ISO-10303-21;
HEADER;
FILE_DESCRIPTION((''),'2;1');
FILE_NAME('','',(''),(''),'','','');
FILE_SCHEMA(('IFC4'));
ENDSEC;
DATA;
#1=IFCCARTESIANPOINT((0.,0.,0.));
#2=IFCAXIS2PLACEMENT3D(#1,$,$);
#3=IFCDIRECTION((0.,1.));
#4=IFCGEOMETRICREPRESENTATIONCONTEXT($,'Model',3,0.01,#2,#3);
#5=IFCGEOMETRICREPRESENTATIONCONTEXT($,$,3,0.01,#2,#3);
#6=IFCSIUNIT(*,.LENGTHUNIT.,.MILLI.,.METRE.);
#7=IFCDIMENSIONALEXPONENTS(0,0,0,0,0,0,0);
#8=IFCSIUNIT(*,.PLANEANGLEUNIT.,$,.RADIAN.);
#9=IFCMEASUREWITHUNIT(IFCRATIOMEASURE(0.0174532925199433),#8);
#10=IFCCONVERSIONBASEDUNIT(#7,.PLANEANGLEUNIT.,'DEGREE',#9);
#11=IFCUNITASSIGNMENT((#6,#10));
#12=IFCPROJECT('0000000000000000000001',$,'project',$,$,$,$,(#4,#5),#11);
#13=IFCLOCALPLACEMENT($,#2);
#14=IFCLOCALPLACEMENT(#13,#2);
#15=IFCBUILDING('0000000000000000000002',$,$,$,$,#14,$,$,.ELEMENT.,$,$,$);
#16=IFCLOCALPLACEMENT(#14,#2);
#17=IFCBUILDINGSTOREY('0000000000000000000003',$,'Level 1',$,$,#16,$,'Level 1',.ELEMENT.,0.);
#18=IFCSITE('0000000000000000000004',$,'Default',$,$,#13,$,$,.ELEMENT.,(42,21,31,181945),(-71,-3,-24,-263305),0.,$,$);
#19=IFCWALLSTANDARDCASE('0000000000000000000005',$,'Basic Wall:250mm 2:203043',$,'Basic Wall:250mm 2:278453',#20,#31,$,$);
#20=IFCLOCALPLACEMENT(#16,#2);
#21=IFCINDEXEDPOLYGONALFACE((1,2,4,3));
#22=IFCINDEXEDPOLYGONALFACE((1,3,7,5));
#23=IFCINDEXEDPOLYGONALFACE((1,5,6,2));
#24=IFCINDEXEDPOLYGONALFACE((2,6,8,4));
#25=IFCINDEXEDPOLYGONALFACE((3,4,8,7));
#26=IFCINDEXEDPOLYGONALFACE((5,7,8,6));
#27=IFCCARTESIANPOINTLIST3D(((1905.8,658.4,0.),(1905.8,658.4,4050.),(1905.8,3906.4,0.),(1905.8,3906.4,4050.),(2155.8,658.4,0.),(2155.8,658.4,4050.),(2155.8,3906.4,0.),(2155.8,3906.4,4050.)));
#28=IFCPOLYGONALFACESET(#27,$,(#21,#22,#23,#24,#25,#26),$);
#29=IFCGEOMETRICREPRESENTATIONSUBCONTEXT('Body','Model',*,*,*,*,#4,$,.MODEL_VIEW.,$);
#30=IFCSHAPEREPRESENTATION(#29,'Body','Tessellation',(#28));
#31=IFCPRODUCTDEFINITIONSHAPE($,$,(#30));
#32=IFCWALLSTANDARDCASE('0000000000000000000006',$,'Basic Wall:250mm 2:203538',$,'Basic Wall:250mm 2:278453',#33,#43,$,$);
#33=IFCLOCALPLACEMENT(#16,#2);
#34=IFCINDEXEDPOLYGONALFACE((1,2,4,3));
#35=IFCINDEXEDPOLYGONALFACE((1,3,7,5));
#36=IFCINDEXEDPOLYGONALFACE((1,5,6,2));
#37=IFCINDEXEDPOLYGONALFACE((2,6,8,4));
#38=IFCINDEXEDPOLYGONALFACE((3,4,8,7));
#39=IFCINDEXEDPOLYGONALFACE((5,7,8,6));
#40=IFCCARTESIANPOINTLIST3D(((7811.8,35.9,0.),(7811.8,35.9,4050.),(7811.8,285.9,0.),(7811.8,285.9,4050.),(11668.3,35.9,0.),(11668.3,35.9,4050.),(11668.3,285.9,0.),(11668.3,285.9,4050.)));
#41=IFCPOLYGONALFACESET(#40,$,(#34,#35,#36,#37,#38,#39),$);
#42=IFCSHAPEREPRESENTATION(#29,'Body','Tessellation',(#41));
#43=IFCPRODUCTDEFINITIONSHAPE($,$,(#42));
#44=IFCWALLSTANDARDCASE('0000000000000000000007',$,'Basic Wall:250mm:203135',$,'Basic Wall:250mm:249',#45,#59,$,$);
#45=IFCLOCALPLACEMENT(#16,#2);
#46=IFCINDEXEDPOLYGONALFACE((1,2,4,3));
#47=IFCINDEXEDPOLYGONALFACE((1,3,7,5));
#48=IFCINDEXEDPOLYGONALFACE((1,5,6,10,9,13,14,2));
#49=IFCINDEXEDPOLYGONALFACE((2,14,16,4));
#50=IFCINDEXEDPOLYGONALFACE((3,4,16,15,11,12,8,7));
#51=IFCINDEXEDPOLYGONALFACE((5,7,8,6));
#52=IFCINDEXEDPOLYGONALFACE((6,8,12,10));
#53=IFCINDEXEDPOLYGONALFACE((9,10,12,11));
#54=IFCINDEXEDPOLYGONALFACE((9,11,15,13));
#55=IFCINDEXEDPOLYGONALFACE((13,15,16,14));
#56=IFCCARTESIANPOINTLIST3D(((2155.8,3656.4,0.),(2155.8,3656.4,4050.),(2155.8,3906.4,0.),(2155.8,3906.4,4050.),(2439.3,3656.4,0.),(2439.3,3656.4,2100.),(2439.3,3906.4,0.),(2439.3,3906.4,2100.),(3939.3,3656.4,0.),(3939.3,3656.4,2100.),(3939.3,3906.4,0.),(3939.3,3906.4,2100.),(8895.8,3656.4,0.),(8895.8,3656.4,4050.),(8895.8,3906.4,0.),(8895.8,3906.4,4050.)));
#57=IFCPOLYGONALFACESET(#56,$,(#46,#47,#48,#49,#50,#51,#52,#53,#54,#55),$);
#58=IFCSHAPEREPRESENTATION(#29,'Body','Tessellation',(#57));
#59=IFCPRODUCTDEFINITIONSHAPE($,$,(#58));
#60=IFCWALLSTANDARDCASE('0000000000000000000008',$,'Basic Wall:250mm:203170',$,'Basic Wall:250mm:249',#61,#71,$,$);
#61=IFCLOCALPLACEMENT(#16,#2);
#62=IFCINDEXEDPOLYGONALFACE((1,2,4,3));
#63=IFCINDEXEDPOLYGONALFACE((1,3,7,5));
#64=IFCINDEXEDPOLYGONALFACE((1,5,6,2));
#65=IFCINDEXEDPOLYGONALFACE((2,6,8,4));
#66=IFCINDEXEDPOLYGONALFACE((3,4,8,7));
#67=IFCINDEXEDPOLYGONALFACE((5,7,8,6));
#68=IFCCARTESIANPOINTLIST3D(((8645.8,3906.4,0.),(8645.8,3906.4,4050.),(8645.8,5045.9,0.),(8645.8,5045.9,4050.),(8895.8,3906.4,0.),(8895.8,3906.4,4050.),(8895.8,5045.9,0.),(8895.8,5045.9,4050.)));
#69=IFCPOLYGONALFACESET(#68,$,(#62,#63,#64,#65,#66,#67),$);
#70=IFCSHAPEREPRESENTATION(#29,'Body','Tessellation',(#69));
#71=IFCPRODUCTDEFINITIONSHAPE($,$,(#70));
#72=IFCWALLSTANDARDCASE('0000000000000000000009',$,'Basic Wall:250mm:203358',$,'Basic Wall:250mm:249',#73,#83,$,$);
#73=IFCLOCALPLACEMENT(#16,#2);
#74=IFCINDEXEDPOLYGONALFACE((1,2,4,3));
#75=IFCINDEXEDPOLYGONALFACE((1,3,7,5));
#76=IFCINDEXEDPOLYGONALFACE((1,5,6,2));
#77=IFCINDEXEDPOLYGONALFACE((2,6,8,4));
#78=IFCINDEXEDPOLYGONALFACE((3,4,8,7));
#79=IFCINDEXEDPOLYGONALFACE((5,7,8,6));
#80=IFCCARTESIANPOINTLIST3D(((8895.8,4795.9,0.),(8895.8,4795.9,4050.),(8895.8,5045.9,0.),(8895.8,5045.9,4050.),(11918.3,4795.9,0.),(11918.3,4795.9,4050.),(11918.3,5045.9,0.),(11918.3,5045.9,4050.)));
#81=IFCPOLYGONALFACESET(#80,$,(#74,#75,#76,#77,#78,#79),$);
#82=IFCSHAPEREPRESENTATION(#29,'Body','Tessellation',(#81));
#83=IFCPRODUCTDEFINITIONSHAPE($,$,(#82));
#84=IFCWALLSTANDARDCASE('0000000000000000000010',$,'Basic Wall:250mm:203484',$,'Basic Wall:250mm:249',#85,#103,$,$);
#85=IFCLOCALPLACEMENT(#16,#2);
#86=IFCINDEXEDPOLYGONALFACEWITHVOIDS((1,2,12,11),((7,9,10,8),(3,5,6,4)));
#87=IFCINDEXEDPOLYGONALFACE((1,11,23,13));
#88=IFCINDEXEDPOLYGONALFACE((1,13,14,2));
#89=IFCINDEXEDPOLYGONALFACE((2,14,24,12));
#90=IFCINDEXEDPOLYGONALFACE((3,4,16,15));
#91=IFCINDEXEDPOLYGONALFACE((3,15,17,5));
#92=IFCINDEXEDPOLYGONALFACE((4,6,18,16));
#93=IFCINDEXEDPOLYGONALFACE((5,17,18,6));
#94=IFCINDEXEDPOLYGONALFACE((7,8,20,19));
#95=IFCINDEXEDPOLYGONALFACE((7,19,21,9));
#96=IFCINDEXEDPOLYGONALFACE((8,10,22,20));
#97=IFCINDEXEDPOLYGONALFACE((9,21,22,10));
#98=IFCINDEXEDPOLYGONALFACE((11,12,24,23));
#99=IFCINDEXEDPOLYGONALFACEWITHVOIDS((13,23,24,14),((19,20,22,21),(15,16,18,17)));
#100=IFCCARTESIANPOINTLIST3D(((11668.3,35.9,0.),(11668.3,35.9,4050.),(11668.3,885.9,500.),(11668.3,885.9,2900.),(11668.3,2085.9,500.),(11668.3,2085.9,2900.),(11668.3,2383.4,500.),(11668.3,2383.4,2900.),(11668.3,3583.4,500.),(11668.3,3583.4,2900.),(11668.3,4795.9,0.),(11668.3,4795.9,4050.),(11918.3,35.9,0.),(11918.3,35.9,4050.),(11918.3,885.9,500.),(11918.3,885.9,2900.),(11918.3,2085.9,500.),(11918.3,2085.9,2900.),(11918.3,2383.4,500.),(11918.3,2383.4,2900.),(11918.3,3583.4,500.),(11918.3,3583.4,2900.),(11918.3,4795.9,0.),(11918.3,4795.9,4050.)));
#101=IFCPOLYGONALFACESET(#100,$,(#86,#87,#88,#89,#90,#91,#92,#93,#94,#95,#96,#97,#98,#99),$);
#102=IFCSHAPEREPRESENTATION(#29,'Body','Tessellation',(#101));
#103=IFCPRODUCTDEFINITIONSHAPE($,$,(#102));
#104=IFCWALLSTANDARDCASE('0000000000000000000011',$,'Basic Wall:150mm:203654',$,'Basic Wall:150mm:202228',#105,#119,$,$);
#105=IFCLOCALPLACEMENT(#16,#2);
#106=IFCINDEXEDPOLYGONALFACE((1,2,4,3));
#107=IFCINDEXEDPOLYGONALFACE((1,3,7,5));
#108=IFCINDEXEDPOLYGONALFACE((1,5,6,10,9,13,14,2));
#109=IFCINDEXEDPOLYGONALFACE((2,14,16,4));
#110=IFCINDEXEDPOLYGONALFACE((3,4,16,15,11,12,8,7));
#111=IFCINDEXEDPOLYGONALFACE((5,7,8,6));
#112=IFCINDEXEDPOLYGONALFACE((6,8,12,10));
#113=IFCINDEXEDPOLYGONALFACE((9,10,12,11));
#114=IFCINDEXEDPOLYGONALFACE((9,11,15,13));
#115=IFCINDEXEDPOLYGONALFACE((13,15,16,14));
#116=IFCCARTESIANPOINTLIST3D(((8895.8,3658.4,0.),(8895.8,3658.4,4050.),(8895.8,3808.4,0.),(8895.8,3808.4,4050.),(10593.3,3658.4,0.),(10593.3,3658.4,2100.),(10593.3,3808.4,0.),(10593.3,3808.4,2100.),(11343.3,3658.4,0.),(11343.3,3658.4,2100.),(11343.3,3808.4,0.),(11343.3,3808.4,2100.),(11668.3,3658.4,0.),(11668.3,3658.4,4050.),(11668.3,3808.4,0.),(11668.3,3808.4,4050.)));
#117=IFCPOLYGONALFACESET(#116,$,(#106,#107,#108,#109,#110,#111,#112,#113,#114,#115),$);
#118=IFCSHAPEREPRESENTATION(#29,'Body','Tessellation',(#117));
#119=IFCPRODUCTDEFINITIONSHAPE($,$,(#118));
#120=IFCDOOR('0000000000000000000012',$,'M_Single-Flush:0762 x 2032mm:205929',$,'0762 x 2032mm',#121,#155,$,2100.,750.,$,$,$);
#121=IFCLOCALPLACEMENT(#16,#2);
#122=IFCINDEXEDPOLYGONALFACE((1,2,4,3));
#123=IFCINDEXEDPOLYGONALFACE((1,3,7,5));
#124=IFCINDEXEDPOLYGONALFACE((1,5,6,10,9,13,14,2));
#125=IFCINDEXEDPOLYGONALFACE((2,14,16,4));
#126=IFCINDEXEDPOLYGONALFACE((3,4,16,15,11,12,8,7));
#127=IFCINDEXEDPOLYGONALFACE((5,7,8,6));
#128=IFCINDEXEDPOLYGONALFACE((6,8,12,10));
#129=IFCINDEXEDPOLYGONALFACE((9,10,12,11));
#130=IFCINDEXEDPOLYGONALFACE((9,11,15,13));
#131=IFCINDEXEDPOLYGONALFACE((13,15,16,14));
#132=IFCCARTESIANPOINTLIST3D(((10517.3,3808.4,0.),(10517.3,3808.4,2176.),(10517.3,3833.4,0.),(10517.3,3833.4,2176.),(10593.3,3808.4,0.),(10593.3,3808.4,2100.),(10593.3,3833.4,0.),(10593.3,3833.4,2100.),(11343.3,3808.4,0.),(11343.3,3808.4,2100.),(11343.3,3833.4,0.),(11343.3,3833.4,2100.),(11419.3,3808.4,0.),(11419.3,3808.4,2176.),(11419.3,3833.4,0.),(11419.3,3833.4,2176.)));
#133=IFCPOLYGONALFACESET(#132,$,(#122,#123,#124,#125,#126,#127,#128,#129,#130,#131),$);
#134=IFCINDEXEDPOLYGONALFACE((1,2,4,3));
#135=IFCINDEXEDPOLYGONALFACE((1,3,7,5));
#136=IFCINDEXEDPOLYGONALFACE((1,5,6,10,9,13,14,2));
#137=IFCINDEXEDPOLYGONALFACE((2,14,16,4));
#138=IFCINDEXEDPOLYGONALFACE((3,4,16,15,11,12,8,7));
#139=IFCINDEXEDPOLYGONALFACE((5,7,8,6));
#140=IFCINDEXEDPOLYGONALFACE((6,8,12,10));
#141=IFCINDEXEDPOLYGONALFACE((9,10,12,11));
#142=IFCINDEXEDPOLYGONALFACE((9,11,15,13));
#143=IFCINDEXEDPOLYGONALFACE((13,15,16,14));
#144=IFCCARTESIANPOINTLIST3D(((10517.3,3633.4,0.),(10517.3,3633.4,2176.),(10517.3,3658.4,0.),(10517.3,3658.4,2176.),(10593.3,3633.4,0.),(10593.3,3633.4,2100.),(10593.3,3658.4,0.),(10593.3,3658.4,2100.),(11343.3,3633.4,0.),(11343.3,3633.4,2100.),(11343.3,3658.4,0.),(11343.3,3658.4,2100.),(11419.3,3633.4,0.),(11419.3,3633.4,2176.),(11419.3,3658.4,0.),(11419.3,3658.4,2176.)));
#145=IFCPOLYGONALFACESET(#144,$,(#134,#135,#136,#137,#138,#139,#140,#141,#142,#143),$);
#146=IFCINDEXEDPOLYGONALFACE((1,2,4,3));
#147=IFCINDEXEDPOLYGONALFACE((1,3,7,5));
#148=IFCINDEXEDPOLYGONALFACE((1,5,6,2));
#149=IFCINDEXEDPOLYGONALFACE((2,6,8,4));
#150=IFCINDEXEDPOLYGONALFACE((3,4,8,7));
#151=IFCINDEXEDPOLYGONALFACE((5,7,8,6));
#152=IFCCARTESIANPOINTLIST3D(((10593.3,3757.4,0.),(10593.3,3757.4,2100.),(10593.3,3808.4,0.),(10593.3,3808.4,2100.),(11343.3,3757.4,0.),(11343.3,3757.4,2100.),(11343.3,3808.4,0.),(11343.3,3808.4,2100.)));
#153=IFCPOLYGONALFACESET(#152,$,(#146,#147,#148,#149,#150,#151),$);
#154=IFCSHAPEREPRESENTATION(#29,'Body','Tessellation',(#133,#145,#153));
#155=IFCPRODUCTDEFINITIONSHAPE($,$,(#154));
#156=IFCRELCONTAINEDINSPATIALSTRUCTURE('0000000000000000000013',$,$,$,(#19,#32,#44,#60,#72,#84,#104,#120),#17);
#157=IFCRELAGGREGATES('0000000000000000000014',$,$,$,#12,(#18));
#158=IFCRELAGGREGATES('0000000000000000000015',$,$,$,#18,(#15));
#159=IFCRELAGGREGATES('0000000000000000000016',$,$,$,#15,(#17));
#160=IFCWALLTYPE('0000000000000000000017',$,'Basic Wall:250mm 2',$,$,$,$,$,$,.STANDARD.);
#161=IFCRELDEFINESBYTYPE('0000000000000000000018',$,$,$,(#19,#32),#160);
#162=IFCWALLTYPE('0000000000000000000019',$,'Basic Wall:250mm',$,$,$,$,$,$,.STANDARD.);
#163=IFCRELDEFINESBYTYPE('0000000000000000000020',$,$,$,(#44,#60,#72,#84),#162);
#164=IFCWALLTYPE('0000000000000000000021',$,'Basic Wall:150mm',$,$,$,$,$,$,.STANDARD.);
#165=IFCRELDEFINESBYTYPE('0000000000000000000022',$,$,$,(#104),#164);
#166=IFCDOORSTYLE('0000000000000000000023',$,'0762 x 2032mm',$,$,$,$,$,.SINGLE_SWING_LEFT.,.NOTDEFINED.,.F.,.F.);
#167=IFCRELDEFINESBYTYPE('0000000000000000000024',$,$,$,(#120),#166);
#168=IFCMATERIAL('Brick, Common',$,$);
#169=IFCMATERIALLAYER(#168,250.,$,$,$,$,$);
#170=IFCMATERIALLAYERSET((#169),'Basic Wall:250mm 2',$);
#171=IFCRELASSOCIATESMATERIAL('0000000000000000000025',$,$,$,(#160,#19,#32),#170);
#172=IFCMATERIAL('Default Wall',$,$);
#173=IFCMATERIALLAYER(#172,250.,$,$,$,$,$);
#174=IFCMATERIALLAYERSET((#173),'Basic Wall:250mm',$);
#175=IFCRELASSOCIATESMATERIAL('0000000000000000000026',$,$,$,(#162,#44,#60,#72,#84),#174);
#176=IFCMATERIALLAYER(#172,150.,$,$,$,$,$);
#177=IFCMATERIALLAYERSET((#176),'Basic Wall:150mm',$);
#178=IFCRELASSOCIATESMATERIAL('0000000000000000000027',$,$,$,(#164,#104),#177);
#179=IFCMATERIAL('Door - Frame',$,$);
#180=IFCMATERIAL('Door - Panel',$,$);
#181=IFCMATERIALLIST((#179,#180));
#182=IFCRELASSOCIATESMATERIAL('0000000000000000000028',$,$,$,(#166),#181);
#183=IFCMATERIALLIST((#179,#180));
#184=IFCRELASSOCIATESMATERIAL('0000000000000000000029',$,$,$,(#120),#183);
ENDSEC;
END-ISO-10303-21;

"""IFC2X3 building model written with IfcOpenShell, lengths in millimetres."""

from ifc_helpers import new_model, entity, si_unit, converted_unit, direction, frame, frame_2d, origin, place, context, subcontext, project, spatial, polyline, rectangle, outline, extrude, source, transform, mapped, material, material_list, layer, layer_set, layer_usage, type_object, type_shapes, element, fill, save


model = new_model("IFC2X3")

# Units and contexts
model_context = context("Model", 3, precision=0.01, world=origin(), true_north=direction((0.0, 1.0)))
context_of_model = context(None, 3, precision=0.01, world=origin(), true_north=direction((0.0, 1.0)))
body_context = subcontext(model_context, "Body", "Model", "MODEL_VIEW")
ifc_project = project(units=[si_unit("LENGTHUNIT", "METRE", prefix="MILLI"), converted_unit("PLANEANGLEUNIT", "DEGREE", entity("IfcRatioMeasure", 0.0174532925199433), si_unit("PLANEANGLEUNIT", "RADIAN"), dimensions=[0, 0, 0, 0, 0, 0, 0])], contexts=[model_context, context_of_model])

# Site, building, storey
site_placement = place(None, origin())
site = spatial("IfcSite", under=ifc_project, at=site_placement, Name="Default", CompositionType="ELEMENT", RefLatitude=(42, 21, 31, 181945), RefLongitude=(-71, -3, -24, -263305), RefElevation=0.0)
building_placement = place(site_placement, origin())
building = spatial("IfcBuilding", under=site, at=building_placement, CompositionType="ELEMENT")
storey_placement = place(building_placement, origin())
storey = spatial("IfcBuildingStorey", under=building, at=storey_placement, Name="Level 1", LongName="Level 1", CompositionType="ELEMENT", Elevation=0.0)

# Shared definitions
ifc_material_1 = material(Name="Default Wall")

# Walls
ifc_material_2 = material(Name="Brick, Common")
ifc_layer_1 = layer(ifc_material_2, 250.0)
ifc_layer_set_1 = layer_set([ifc_layer_1], Name="Basic Wall:250mm 2")
ifc_layer_usage_1 = layer_usage(ifc_layer_set_1, "AXIS2", "NEGATIVE", 125.0)
wall_type_1 = type_object("IfcWallType", Name="Basic Wall:250mm 2", PredefinedType="STANDARD", material=ifc_layer_set_1)
wall_1_placement = place(storey_placement, frame((2030.8, 3906.4, 0.0), z_axis=(0.0, 0.0, 1.0), x_axis=(0.0, -1.0, 0.0)))
element("IfcWallStandardCase", 1, at=wall_1_placement, inside=storey, type_object=wall_type_1, material=ifc_layer_usage_1, Name="Basic Wall:250mm 2:203043", ObjectType="Basic Wall:250mm 2:278453", context=body_context, shape_type="SweptSolid", body=[
    extrude(rectangle(XDim=3248.1, YDim=250.0, at=frame_2d((1624.0, 0.0), x_axis=(-1.0, 0.0))), origin(), (0.0, 0.0, 1.0), 4050.0),
])
ifc_layer_usage_2 = layer_usage(ifc_layer_set_1, "AXIS2", "NEGATIVE", 125.0)
wall_2_placement = place(storey_placement, frame((11668.3, 160.9, 0.0), z_axis=(0.0, 0.0, 1.0), x_axis=(-1.0, 0.0, 0.0)))
element("IfcWallStandardCase", 2, at=wall_2_placement, inside=storey, type_object=wall_type_1, material=ifc_layer_usage_2, Name="Basic Wall:250mm 2:203538", ObjectType="Basic Wall:250mm 2:278453", context=body_context, shape_type="SweptSolid", body=[
    extrude(rectangle(XDim=3856.5, YDim=250.0, at=frame_2d((1928.2, 0.0), x_axis=(-1.0, 0.0))), origin(), (0.0, 0.0, 1.0), 4050.0),
])

# Wall, opening
ifc_layer_2 = layer(ifc_material_1, 250.0)
ifc_layer_set_2 = layer_set([ifc_layer_2], Name="Basic Wall:250mm")
ifc_layer_usage_3 = layer_usage(ifc_layer_set_2, "AXIS2", "NEGATIVE", 125.0)
wall_type_2 = type_object("IfcWallType", Name="Basic Wall:250mm", PredefinedType="STANDARD", material=ifc_layer_set_2)
wall_3_placement = place(storey_placement, frame((2155.8, 3781.4, 0.0)))
wall_3 = element("IfcWallStandardCase", 3, at=wall_3_placement, inside=storey, type_object=wall_type_2, material=ifc_layer_usage_3, Name="Basic Wall:250mm:203135", ObjectType="Basic Wall:250mm:249", context=body_context, shape_type="SweptSolid", body=[
    extrude(rectangle(XDim=6740.0, YDim=250.0, at=frame_2d((3370.0, 0.0), x_axis=(-1.0, 0.0))), origin(), (0.0, 0.0, 1.0), 4050.0),
])
opening_1_placement = place(wall_3_placement, frame((1783.5, 125.0, 0.0)))
element("IfcOpeningElement", 4, at=opening_1_placement, cuts=wall_3, ObjectType="Opening", context=body_context, shape_type="SweptSolid", body=[
    extrude(rectangle(XDim=2100.0, YDim=1500.0, at=frame_2d((1050.0, 750.0), x_axis=(1.0, 0.0))), frame((0.0, 0.0, 0.0), z_axis=(0.0, -1.0, 0.0), x_axis=(0.0, 0.0, 1.0)), (0.0, 0.0, 1.0), 250.0),
])

# Walls
ifc_layer_usage_4 = layer_usage(ifc_layer_set_2, "AXIS2", "NEGATIVE", 125.0)
wall_4_placement = place(storey_placement, frame((8770.8, 3906.4, 0.0), z_axis=(0.0, 0.0, 1.0), x_axis=(0.0, 1.0, 0.0)))
element("IfcWallStandardCase", 5, at=wall_4_placement, inside=storey, type_object=wall_type_2, material=ifc_layer_usage_4, Name="Basic Wall:250mm:203170", ObjectType="Basic Wall:250mm:249", context=body_context, shape_type="SweptSolid", body=[
    extrude(rectangle(XDim=1139.4, YDim=250.0, at=frame_2d((569.7, 0.0), x_axis=(-1.0, 0.0))), origin(), (0.0, 0.0, 1.0), 4050.0),
])
ifc_layer_usage_5 = layer_usage(ifc_layer_set_2, "AXIS2", "NEGATIVE", 125.0)
wall_5_placement = place(storey_placement, frame((8895.8, 4920.9, 0.0)))
element("IfcWallStandardCase", 6, at=wall_5_placement, inside=storey, type_object=wall_type_2, material=ifc_layer_usage_5, Name="Basic Wall:250mm:203358", ObjectType="Basic Wall:250mm:249", context=body_context, shape_type="SweptSolid", body=[
    extrude(rectangle(XDim=3022.5, YDim=250.0, at=frame_2d((1511.2, 0.0), x_axis=(-1.0, 0.0))), origin(), (0.0, 0.0, 1.0), 4050.0),
])

# Wall, openings
ifc_layer_usage_6 = layer_usage(ifc_layer_set_2, "AXIS2", "NEGATIVE", 125.0)
wall_6_placement = place(storey_placement, frame((11793.3, 4795.9, 0.0), z_axis=(0.0, 0.0, 1.0), x_axis=(0.0, -1.0, 0.0)))
wall_6 = element("IfcWallStandardCase", 7, at=wall_6_placement, inside=storey, type_object=wall_type_2, material=ifc_layer_usage_6, Name="Basic Wall:250mm:203484", ObjectType="Basic Wall:250mm:249", context=body_context, shape_type="SweptSolid", body=[
    extrude(rectangle(XDim=4760.0, YDim=250.0, at=frame_2d((2380.0, 0.0), x_axis=(-1.0, 0.0))), origin(), (0.0, 0.0, 1.0), 4050.0),
])
opening_2_placement = place(wall_6_placement, frame((1212.5, -125.0, 500.0)))
element("IfcOpeningElement", 8, at=opening_2_placement, cuts=wall_6, ObjectType="Opening", context=body_context, shape_type="SweptSolid", body=[
    extrude(rectangle(XDim=2400.0, YDim=1200.0, at=frame_2d((1200.0, 600.0), x_axis=(-1.0, 0.0))), frame((0.0, 0.0, 0.0), z_axis=(0.0, 1.0, 0.0), x_axis=(0.0, 0.0, 1.0)), (0.0, 0.0, 1.0), 250.0),
])
opening_3_placement = place(wall_6_placement, frame((2710.0, -125.0, 500.0)))
element("IfcOpeningElement", 9, at=opening_3_placement, cuts=wall_6, ObjectType="Opening", context=body_context, shape_type="SweptSolid", body=[
    extrude(rectangle(XDim=2400.0, YDim=1200.0, at=frame_2d((1200.0, 600.0), x_axis=(-1.0, 0.0))), frame((0.0, 0.0, 0.0), z_axis=(0.0, 1.0, 0.0), x_axis=(0.0, 0.0, 1.0)), (0.0, 0.0, 1.0), 250.0),
])

# Wall, opening, door
ifc_layer_3 = layer(ifc_material_1, 150.0)
ifc_layer_set_3 = layer_set([ifc_layer_3], Name="Basic Wall:150mm")
ifc_layer_usage_7 = layer_usage(ifc_layer_set_3, "AXIS2", "NEGATIVE", 75.0)
wall_type_3 = type_object("IfcWallType", Name="Basic Wall:150mm", PredefinedType="STANDARD", material=ifc_layer_set_3)
wall_7_placement = place(storey_placement, frame((8895.8, 3733.4, 0.0)))
wall_7 = element("IfcWallStandardCase", 10, at=wall_7_placement, inside=storey, type_object=wall_type_3, material=ifc_layer_usage_7, Name="Basic Wall:150mm:203654", ObjectType="Basic Wall:150mm:202228", context=body_context, shape_type="SweptSolid", body=[
    extrude(rectangle(XDim=2772.5, YDim=150.0, at=frame_2d((1386.2, 0.0), x_axis=(-1.0, 0.0))), origin(), (0.0, 0.0, 1.0), 4050.0),
])
opening_4_placement = place(wall_7_placement, frame((1697.5, -75.0, 0.0)))
opening_4 = element("IfcOpeningElement", 11, at=opening_4_placement, cuts=wall_7, ObjectType="Opening", context=body_context, shape_type="SweptSolid", body=[
    extrude(rectangle(XDim=750.0, YDim=2100.0, at=frame_2d((1050.0, 375.0), x_axis=(0.0, -1.0))), frame((0.0, 0.0, 0.0), z_axis=(0.0, 1.0, 0.0), x_axis=(0.0, 0.0, 1.0)), (0.0, 0.0, 1.0), 150.0),
])
ifc_material_3 = material(Name="Door - Frame")
ifc_material_4 = material(Name="Door - Panel")
ifc_material_list_1 = material_list([ifc_material_3, ifc_material_4])
ifc_material_list_2 = material_list([ifc_material_3, ifc_material_4])
door_style = type_object("IfcDoorStyle", Name="0762 x 2032mm", ConstructionType="NOTDEFINED", OperationType="SINGLE_SWING_LEFT", ParameterTakesPrecedence=False, Sizeable=False, material=ifc_material_list_2)
shared_shape_1 = source(origin(), body_context, "Body", "SweptSolid", [
    extrude(outline(polyline([(-451.0, -1107.0), (451.0, -1107.0), (451.0, 1069.0), (375.0, 1069.0), (375.0, -1031.0), (-375.0, -1031.0), (-375.0, 1069.0), (-451.0, 1069.0), (-451.0, -1107.0)])), frame((375.0, 175.0, 1069.0), z_axis=(0.0, -1.0, 0.0), x_axis=(-1.0, 0.0, 0.0)), (0.0, 0.0, 1.0), 25.0),
    extrude(outline(polyline([(-1107.0, -451.0), (1069.0, -451.0), (1069.0, -375.0), (-1031.0, -375.0), (-1031.0, 375.0), (1069.0, 375.0), (1069.0, 451.0), (-1107.0, 451.0), (-1107.0, -451.0)])), frame((375.0, 0.0, 1069.0), z_axis=(0.0, -1.0, 0.0), x_axis=(0.0, 0.0, -1.0)), (0.0, 0.0, 1.0), 25.0),
    extrude(rectangle(XDim=750.0, YDim=51.0, at=frame_2d((0.0, 0.0), x_axis=(1.0, 0.0))), frame((375.0, 124.5, 0.0)), (0.0, 0.0, 1.0), 2100.0),
])
type_shapes(door_style, [shared_shape_1])
door_placement = place(opening_4_placement, origin())
door = element("IfcDoor", 12, at=door_placement, inside=storey, type_object=door_style, material=ifc_material_list_1, Name="M_Single-Flush:0762 x 2032mm:205929", ObjectType="0762 x 2032mm", OverallHeight=2100.0, OverallWidth=750.0, context=body_context, shape_type="MappedRepresentation", body=[
    mapped(shared_shape_1, transform((0.0, 0.0, 0.0), scale=1.0)),
])
fill(opening_4, door)

save(model, "model.ifc")
